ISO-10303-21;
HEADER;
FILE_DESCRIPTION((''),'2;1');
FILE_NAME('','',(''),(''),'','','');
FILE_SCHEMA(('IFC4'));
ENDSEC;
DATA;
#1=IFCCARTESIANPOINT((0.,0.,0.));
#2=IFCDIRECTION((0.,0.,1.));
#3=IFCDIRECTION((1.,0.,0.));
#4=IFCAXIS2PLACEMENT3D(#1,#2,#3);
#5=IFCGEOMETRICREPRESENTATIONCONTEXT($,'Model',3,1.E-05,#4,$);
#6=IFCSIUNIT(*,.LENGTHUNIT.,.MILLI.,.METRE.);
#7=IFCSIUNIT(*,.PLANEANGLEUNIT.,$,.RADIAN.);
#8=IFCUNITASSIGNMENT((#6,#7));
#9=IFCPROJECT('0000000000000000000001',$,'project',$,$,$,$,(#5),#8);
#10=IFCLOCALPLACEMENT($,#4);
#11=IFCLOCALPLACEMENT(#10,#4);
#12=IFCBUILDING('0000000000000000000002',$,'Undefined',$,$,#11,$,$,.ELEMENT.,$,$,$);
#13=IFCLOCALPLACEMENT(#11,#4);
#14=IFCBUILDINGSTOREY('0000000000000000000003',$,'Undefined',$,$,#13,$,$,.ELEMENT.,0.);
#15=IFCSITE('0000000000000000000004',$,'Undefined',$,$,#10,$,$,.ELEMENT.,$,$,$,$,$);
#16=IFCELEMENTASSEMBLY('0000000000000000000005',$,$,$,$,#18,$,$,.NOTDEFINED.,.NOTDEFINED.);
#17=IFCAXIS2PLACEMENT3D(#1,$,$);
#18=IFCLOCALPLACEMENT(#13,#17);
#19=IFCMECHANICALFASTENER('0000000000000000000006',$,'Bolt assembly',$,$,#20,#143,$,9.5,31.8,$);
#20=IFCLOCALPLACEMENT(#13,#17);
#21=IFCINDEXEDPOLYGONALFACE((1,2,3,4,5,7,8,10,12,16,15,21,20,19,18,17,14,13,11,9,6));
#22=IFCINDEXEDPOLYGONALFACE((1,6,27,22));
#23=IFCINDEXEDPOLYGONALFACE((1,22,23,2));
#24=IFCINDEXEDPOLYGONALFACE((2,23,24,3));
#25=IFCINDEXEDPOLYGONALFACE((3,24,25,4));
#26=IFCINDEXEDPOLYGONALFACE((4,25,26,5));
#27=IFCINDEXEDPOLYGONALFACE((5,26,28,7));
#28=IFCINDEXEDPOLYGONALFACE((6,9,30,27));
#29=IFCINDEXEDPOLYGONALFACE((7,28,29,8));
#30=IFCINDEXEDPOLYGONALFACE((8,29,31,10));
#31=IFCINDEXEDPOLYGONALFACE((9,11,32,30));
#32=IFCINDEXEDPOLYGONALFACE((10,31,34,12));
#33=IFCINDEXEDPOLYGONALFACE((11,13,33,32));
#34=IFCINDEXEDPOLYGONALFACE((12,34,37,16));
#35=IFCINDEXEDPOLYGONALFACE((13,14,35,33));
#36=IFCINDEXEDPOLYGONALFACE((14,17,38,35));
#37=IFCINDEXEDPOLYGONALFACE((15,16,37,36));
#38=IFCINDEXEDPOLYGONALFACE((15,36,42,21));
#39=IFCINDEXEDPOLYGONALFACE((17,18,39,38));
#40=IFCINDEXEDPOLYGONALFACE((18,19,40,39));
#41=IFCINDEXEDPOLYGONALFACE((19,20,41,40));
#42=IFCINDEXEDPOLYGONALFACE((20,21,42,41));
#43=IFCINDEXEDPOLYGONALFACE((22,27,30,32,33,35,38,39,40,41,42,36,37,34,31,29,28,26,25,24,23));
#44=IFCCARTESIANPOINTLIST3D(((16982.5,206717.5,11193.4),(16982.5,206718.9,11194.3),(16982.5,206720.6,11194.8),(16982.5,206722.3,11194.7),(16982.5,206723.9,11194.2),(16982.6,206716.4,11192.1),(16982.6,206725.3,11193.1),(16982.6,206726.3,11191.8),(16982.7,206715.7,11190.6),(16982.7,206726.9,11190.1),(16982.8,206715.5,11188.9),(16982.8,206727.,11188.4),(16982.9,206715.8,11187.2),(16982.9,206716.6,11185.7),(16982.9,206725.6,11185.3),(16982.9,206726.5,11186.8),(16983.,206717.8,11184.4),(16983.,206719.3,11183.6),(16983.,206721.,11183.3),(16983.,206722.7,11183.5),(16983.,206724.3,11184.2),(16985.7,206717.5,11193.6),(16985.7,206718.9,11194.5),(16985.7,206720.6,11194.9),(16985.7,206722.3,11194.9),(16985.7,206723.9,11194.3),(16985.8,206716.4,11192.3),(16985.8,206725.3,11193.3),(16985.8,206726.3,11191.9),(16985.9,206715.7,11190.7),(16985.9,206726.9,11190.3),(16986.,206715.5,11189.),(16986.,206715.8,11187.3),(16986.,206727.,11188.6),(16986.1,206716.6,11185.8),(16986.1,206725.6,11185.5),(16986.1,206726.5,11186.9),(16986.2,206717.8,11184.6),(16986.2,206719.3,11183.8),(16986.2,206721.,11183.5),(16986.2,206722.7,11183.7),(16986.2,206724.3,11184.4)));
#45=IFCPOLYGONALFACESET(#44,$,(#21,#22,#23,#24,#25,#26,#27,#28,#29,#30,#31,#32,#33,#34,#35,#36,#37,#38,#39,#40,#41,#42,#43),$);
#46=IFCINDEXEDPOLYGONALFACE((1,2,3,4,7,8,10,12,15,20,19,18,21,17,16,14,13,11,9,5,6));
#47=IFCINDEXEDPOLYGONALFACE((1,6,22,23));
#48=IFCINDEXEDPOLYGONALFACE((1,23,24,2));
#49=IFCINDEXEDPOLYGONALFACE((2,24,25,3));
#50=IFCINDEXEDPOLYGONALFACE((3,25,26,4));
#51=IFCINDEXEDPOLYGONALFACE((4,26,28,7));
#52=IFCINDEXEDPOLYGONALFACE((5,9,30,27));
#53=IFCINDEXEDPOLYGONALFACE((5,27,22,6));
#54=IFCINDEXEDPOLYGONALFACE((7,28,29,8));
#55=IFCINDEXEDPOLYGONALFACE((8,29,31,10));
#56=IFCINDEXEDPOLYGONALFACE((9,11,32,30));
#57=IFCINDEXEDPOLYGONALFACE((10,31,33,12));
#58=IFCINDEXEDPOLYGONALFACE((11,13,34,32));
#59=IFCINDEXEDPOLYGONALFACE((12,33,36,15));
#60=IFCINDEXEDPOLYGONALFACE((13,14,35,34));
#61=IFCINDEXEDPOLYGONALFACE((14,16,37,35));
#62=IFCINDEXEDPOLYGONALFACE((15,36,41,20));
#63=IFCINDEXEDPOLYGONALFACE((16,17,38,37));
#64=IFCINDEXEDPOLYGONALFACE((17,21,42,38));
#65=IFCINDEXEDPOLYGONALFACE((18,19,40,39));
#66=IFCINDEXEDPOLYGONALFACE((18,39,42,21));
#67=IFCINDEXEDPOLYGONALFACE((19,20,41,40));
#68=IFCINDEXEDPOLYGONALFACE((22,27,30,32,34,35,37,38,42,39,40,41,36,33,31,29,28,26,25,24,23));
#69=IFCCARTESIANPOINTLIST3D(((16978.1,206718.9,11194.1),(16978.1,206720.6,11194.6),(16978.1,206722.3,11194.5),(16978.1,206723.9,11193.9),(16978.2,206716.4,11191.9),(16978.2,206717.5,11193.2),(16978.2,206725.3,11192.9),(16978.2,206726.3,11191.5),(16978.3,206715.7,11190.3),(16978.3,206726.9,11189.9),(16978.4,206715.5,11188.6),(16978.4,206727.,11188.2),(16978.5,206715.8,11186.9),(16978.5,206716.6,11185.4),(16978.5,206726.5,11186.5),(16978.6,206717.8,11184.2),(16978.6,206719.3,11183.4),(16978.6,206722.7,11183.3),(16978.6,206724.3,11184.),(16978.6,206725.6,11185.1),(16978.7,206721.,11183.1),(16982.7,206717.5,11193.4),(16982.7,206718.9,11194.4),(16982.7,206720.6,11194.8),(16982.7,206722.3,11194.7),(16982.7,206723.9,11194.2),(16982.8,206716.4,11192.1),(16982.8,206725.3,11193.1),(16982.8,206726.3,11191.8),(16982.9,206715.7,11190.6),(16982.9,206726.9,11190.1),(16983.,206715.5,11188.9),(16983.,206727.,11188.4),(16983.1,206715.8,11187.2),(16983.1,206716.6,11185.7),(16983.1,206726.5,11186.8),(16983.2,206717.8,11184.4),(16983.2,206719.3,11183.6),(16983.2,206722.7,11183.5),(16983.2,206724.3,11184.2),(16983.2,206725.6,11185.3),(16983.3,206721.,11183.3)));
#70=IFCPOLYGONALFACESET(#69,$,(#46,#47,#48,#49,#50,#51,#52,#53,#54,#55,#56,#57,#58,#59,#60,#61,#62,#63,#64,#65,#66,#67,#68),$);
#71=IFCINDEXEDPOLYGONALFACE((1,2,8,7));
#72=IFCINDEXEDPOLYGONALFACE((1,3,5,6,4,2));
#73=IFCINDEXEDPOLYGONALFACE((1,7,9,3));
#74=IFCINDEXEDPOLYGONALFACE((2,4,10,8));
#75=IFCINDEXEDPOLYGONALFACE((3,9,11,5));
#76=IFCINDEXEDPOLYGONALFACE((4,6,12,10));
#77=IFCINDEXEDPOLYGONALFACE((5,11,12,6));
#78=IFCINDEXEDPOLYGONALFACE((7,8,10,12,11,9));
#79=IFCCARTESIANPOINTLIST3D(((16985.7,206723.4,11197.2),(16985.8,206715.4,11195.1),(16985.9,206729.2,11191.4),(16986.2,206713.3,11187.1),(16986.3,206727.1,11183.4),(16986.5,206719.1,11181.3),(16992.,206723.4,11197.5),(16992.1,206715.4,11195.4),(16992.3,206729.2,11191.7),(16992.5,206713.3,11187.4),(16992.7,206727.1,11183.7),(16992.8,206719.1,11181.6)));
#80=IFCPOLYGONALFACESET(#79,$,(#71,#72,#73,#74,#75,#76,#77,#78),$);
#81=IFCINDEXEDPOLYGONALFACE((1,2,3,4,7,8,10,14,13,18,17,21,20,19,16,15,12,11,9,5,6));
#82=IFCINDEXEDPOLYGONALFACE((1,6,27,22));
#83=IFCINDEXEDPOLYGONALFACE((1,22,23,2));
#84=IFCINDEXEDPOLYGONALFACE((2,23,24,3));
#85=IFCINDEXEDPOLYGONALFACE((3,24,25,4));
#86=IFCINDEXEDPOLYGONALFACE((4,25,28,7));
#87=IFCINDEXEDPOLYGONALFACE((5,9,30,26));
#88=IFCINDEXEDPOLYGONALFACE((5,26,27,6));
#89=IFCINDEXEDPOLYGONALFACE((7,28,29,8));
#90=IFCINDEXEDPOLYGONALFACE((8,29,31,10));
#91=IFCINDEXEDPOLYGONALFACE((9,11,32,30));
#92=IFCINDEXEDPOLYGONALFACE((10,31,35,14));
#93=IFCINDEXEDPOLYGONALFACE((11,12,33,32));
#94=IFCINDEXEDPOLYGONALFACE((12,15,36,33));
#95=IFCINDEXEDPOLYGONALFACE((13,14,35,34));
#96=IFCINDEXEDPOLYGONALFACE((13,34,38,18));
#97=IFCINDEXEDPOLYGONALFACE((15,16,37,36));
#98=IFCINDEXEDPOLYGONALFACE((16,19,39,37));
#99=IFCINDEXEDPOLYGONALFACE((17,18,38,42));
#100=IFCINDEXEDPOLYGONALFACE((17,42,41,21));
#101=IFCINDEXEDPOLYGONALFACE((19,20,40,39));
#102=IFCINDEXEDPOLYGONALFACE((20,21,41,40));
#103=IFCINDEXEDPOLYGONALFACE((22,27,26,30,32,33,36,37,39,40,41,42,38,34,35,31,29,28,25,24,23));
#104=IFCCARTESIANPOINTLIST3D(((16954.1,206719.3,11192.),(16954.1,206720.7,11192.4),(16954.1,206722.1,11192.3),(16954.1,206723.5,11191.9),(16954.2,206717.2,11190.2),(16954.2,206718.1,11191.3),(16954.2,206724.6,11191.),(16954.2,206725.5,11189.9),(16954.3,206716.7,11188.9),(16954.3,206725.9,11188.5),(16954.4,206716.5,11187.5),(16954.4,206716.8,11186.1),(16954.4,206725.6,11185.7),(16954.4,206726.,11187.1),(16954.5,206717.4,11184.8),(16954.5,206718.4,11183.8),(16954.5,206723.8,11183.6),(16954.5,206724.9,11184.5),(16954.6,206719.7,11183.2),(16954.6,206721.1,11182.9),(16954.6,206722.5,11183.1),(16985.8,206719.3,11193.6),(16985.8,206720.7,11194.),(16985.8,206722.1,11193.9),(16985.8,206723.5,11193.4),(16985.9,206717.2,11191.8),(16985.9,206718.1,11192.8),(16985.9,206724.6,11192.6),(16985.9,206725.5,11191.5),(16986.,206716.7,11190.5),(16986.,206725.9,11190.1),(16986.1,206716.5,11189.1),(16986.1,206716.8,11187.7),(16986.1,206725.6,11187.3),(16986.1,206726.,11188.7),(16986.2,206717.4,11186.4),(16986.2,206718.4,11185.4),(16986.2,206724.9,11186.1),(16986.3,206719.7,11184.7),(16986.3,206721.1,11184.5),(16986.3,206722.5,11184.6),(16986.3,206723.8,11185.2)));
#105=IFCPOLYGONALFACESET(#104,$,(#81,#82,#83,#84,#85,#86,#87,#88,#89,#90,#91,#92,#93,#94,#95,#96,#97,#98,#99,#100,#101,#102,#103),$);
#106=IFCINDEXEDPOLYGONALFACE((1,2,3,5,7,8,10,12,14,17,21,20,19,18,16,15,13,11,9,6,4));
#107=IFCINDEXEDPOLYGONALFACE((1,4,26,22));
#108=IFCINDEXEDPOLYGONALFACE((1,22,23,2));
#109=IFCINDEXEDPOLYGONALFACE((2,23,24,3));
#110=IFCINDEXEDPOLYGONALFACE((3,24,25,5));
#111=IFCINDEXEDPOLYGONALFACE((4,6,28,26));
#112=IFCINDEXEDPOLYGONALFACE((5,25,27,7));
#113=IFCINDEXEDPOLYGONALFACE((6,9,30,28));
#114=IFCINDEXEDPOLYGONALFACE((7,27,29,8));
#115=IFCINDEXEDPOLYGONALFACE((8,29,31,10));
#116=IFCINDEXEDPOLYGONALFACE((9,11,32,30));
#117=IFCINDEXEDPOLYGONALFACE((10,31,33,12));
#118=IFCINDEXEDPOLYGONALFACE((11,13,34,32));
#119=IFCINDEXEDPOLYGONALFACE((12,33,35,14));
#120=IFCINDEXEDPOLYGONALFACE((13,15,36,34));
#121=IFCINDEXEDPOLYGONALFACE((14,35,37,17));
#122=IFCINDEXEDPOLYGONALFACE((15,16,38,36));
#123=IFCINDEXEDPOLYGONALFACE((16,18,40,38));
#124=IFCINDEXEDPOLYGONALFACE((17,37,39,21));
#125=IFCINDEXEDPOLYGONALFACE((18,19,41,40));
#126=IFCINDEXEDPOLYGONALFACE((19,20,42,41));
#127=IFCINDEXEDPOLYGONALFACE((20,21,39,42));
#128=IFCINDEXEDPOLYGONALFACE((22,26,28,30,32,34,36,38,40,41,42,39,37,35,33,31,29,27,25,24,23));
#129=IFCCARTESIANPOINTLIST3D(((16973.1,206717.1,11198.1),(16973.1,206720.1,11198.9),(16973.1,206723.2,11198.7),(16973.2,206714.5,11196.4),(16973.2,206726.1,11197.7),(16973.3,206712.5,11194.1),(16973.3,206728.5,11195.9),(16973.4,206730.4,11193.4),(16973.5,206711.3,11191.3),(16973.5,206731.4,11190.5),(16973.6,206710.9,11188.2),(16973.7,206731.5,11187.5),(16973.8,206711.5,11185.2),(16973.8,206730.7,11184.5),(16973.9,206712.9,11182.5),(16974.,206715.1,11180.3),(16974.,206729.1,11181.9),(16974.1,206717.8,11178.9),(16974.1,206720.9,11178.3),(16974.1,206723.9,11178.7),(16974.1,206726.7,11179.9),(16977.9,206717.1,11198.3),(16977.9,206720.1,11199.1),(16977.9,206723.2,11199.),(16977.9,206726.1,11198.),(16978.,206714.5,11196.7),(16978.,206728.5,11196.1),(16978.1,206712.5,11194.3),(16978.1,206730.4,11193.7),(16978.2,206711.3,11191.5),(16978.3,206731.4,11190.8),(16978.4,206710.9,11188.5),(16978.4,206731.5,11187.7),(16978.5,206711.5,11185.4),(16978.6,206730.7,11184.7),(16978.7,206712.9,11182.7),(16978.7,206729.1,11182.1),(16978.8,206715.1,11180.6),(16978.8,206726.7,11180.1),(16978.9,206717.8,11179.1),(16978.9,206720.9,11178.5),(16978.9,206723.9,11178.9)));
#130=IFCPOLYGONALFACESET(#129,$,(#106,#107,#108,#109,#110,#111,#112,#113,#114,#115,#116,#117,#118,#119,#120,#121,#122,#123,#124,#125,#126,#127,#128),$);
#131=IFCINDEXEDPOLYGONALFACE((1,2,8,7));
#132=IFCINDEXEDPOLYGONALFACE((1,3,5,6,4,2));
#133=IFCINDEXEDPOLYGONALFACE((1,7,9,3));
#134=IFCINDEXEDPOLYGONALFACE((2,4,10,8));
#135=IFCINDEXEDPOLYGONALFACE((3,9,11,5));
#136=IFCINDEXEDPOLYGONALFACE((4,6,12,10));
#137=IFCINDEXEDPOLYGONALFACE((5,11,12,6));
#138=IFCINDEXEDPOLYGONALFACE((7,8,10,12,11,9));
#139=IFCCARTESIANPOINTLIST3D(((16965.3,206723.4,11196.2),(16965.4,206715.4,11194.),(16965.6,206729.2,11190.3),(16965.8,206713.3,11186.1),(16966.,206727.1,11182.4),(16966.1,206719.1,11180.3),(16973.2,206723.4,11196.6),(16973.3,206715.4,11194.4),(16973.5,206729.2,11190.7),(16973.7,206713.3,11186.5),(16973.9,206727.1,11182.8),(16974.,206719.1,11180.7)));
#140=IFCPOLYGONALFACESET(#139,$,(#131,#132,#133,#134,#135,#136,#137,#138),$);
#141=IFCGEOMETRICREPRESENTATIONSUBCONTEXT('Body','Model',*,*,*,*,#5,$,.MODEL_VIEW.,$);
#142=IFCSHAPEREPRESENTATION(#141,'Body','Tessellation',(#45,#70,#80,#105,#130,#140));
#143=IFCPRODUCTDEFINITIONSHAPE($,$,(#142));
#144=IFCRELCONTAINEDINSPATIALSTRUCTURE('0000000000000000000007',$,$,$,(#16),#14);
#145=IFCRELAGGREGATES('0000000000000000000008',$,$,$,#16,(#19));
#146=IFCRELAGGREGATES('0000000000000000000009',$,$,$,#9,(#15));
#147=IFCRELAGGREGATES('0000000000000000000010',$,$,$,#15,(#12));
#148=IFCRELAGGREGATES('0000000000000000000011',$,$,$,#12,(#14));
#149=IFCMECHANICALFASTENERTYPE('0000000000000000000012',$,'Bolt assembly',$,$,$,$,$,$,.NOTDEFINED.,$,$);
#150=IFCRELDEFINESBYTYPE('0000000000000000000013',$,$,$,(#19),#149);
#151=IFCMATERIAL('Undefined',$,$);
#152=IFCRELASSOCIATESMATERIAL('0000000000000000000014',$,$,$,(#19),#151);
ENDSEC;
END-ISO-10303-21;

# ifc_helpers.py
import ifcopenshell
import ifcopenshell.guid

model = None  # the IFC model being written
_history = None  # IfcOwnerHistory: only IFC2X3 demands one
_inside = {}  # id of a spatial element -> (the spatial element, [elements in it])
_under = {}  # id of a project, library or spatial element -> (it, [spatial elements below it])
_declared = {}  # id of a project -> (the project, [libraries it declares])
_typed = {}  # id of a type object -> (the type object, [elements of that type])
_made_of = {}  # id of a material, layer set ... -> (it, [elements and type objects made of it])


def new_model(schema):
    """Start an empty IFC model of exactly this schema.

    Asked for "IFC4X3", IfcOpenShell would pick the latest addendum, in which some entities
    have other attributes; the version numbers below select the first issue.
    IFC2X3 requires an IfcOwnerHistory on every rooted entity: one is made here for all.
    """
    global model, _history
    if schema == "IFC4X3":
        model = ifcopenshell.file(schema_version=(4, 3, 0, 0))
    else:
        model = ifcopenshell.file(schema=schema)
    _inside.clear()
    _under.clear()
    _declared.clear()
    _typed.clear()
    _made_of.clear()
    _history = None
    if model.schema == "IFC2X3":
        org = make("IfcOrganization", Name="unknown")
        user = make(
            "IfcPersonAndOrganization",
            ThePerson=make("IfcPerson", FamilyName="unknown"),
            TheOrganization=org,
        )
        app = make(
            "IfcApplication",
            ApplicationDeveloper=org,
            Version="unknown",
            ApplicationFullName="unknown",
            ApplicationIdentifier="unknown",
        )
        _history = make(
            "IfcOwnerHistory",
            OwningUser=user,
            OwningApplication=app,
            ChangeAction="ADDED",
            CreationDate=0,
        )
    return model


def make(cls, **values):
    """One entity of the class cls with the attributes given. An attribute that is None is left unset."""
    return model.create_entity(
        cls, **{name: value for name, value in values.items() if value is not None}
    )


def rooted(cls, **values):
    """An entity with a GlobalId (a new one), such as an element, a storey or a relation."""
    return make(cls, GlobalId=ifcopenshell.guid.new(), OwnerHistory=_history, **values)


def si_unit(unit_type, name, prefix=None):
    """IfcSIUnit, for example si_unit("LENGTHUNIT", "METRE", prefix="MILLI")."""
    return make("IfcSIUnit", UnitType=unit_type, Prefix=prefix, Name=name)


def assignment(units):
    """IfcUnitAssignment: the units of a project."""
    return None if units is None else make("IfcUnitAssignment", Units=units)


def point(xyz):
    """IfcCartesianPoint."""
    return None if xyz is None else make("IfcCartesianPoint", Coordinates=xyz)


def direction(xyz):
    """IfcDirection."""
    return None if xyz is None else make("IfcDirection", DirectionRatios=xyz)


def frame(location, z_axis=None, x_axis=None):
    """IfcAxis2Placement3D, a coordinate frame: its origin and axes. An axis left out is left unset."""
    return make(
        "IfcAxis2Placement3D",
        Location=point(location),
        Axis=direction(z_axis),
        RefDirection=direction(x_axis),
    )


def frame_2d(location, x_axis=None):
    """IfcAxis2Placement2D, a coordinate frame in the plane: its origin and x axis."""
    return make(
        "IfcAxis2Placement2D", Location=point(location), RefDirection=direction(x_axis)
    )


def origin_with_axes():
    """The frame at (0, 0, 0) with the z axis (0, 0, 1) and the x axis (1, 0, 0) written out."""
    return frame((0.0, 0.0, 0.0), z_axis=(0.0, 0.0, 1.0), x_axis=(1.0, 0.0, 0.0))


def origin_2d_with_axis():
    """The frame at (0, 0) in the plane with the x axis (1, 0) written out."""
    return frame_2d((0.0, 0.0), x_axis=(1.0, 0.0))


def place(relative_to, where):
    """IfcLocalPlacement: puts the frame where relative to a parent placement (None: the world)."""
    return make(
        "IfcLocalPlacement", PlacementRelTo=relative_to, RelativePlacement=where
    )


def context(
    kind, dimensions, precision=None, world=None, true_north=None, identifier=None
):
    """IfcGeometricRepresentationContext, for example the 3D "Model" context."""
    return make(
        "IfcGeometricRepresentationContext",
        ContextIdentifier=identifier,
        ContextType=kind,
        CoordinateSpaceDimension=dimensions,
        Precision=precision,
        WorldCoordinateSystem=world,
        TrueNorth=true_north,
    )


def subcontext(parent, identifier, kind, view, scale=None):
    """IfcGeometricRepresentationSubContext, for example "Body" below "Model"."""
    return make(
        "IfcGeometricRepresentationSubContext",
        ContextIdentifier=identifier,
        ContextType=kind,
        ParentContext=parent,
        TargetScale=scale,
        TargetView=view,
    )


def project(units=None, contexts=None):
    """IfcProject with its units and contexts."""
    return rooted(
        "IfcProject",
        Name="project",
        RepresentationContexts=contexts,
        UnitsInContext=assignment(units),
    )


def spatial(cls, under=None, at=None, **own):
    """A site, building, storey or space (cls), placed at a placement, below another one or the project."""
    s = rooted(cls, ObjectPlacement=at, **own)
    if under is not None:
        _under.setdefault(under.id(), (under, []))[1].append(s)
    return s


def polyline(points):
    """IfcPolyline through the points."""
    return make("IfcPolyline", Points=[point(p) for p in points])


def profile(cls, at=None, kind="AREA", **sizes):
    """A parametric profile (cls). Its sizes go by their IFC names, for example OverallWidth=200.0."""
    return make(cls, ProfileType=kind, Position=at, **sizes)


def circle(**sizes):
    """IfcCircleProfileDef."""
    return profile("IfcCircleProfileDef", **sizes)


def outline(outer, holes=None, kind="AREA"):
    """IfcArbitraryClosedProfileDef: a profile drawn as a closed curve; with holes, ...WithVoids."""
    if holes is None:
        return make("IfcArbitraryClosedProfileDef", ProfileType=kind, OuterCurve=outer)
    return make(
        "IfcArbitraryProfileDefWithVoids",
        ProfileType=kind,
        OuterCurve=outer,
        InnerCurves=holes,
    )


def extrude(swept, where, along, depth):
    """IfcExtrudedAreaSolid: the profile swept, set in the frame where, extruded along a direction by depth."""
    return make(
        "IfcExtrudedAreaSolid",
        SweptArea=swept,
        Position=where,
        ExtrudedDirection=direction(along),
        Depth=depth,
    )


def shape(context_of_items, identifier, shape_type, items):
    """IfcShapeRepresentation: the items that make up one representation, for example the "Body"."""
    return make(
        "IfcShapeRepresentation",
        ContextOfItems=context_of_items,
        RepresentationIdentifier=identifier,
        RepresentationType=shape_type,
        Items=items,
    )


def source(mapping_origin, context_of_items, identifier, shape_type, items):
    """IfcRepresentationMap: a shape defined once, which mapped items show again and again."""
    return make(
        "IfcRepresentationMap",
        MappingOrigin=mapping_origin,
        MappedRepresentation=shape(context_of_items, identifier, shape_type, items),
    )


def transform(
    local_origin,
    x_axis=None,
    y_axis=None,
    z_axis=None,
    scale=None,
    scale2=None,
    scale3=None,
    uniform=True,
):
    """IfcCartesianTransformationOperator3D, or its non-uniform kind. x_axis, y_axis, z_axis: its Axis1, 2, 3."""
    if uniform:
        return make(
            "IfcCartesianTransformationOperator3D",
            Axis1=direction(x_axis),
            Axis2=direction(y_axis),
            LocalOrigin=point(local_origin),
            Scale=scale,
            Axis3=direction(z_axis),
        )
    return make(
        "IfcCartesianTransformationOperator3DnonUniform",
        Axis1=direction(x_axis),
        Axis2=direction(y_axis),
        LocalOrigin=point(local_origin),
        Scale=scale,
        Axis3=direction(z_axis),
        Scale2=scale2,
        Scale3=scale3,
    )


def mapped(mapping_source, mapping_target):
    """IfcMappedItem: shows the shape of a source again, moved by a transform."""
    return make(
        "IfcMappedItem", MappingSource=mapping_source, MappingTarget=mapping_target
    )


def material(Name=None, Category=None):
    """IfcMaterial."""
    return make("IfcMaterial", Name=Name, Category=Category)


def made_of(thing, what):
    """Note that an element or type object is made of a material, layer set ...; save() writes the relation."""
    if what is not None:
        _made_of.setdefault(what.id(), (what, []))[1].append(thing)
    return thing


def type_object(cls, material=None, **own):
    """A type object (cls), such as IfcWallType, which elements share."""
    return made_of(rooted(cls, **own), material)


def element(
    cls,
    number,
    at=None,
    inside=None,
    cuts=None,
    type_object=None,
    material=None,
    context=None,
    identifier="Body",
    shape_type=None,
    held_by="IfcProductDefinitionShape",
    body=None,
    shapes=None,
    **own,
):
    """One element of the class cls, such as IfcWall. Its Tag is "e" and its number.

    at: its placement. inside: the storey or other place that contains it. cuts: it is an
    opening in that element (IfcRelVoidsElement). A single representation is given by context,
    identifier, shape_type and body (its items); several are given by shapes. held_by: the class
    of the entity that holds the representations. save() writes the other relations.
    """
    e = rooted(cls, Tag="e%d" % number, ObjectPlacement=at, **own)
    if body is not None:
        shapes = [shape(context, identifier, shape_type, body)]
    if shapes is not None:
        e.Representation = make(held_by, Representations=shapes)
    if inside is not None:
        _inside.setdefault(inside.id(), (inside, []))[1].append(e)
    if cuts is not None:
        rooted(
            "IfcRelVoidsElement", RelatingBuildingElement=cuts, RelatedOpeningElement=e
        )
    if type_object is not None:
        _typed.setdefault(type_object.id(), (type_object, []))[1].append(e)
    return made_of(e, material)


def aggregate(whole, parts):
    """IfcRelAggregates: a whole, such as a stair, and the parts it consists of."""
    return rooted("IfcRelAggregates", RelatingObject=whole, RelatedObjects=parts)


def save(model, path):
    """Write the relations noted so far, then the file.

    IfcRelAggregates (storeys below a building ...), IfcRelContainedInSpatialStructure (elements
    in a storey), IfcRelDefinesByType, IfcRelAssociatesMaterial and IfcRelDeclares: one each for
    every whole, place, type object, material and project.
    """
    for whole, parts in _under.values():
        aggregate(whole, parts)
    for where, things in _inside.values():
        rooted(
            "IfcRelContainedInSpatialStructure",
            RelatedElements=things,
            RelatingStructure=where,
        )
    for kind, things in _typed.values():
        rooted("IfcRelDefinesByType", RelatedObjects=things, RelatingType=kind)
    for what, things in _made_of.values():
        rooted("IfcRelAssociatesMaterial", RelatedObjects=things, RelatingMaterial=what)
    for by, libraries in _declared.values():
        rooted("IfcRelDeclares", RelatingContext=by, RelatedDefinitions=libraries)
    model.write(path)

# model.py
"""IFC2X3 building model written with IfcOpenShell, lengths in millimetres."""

from ifc_helpers import new_model, si_unit, frame, origin_with_axes, origin_2d_with_axis, place, context, subcontext, project, spatial, polyline, circle, outline, extrude, source, transform, mapped, material, type_object, element, aggregate, save


model = new_model("IFC2X3")

# Units and contexts
model_context = context("Model", 3, precision=1e-05, world=origin_with_axes())
body_context = subcontext(model_context, "Body", "Model", "MODEL_VIEW")
ifc_project = project(units=[si_unit("LENGTHUNIT", "METRE", prefix="MILLI"), si_unit("PLANEANGLEUNIT", "RADIAN")], contexts=[model_context])

# Site, building, storey
site_placement = place(None, origin_with_axes())
site = spatial("IfcSite", under=ifc_project, at=site_placement, Name="Undefined", CompositionType="ELEMENT")
building_placement = place(site_placement, origin_with_axes())
building = spatial("IfcBuilding", under=site, at=building_placement, Name="Undefined", CompositionType="ELEMENT")
storey_placement = place(building_placement, origin_with_axes())
storey = spatial("IfcBuildingStorey", under=building, at=storey_placement, Name="Undefined", CompositionType="ELEMENT", Elevation=0.0)

# Element assembly
assembly_1_placement = place(storey_placement, origin_with_axes())
assembly_1 = element("IfcElementAssembly", 1, at=assembly_1_placement, inside=storey, AssemblyPlace="NOTDEFINED", PredefinedType="NOTDEFINED")

# Mechanical fastener
ifc_material_1 = material(Name="Undefined")
mechanical_fastener_type = type_object("IfcMechanicalFastenerType", Name="Bolt assembly")
shared_shape_1 = source(origin_with_axes(), body_context, "Body", "SweptSolid", [
    extrude(circle(Radius=5.8, at=origin_2d_with_axis()), frame((0.0, -7.6, 0.0), z_axis=(0.0, 1.0, 0.0), x_axis=(1.0, 0.0, 0.0)), (0.0, 0.0, 1.0), 3.2),
    extrude(circle(Radius=5.8, at=origin_2d_with_axis()), frame((0.0, -4.6, 0.0), z_axis=(0.0, 1.0, 0.0), x_axis=(1.0, 0.0, 0.0)), (0.0, 0.0, 1.0), 4.6),
    extrude(outline(polyline([(7.1, -4.1), (7.1, 4.1), (0.0, 8.2), (-7.1, 4.1), (-7.1, -4.1), (0.0, -8.2), (7.1, -4.1)])), frame((0.0, -14.0, 0.0), z_axis=(0.0, 1.0, 0.0), x_axis=(1.0, 0.0, 0.0)), (0.0, 0.0, 1.0), 6.3),
    extrude(circle(Radius=4.8, at=origin_2d_with_axis()), frame((0.0, -7.7, 0.0), z_axis=(0.0, 1.0, 0.0), x_axis=(1.0, 0.0, 0.0)), (0.0, 0.0, 1.0), 31.8),
    extrude(circle(Radius=10.3, at=origin_2d_with_axis()), frame((0.0, 0.0, 0.0), z_axis=(0.0, 1.0, 0.0), x_axis=(1.0, 0.0, 0.0)), (0.0, 0.0, 1.0), 4.8),
    extrude(outline(polyline([(7.1, -4.1), (7.1, 4.1), (0.0, 8.2), (-7.1, 4.1), (-7.1, -4.1), (0.0, -8.2), (7.1, -4.1)])), frame((0.0, 4.8, 0.0), z_axis=(0.0, 1.0, 0.0), x_axis=(1.0, 0.0, 0.0)), (0.0, 0.0, 1.0), 7.9),
])
mechanical_fastener_1_placement = place(assembly_1_placement, frame((16978.4, 206721.2, 11188.8), z_axis=(-0.035282, -0.707107, 0.706226), x_axis=(-0.035282, 0.707107, 0.706226)))
mechanical_fastener_1 = element("IfcMechanicalFastener", 2, at=mechanical_fastener_1_placement, type_object=mechanical_fastener_type, material=ifc_material_1, Name="Bolt assembly", NominalDiameter=9.5, NominalLength=31.8, context=body_context, shape_type="MappedRepresentation", body=[
    mapped(shared_shape_1, transform((0.0, 0.0, 0.0))),
])
aggregate(assembly_1, [mechanical_fastener_1])

save(model, "model.ifc")
